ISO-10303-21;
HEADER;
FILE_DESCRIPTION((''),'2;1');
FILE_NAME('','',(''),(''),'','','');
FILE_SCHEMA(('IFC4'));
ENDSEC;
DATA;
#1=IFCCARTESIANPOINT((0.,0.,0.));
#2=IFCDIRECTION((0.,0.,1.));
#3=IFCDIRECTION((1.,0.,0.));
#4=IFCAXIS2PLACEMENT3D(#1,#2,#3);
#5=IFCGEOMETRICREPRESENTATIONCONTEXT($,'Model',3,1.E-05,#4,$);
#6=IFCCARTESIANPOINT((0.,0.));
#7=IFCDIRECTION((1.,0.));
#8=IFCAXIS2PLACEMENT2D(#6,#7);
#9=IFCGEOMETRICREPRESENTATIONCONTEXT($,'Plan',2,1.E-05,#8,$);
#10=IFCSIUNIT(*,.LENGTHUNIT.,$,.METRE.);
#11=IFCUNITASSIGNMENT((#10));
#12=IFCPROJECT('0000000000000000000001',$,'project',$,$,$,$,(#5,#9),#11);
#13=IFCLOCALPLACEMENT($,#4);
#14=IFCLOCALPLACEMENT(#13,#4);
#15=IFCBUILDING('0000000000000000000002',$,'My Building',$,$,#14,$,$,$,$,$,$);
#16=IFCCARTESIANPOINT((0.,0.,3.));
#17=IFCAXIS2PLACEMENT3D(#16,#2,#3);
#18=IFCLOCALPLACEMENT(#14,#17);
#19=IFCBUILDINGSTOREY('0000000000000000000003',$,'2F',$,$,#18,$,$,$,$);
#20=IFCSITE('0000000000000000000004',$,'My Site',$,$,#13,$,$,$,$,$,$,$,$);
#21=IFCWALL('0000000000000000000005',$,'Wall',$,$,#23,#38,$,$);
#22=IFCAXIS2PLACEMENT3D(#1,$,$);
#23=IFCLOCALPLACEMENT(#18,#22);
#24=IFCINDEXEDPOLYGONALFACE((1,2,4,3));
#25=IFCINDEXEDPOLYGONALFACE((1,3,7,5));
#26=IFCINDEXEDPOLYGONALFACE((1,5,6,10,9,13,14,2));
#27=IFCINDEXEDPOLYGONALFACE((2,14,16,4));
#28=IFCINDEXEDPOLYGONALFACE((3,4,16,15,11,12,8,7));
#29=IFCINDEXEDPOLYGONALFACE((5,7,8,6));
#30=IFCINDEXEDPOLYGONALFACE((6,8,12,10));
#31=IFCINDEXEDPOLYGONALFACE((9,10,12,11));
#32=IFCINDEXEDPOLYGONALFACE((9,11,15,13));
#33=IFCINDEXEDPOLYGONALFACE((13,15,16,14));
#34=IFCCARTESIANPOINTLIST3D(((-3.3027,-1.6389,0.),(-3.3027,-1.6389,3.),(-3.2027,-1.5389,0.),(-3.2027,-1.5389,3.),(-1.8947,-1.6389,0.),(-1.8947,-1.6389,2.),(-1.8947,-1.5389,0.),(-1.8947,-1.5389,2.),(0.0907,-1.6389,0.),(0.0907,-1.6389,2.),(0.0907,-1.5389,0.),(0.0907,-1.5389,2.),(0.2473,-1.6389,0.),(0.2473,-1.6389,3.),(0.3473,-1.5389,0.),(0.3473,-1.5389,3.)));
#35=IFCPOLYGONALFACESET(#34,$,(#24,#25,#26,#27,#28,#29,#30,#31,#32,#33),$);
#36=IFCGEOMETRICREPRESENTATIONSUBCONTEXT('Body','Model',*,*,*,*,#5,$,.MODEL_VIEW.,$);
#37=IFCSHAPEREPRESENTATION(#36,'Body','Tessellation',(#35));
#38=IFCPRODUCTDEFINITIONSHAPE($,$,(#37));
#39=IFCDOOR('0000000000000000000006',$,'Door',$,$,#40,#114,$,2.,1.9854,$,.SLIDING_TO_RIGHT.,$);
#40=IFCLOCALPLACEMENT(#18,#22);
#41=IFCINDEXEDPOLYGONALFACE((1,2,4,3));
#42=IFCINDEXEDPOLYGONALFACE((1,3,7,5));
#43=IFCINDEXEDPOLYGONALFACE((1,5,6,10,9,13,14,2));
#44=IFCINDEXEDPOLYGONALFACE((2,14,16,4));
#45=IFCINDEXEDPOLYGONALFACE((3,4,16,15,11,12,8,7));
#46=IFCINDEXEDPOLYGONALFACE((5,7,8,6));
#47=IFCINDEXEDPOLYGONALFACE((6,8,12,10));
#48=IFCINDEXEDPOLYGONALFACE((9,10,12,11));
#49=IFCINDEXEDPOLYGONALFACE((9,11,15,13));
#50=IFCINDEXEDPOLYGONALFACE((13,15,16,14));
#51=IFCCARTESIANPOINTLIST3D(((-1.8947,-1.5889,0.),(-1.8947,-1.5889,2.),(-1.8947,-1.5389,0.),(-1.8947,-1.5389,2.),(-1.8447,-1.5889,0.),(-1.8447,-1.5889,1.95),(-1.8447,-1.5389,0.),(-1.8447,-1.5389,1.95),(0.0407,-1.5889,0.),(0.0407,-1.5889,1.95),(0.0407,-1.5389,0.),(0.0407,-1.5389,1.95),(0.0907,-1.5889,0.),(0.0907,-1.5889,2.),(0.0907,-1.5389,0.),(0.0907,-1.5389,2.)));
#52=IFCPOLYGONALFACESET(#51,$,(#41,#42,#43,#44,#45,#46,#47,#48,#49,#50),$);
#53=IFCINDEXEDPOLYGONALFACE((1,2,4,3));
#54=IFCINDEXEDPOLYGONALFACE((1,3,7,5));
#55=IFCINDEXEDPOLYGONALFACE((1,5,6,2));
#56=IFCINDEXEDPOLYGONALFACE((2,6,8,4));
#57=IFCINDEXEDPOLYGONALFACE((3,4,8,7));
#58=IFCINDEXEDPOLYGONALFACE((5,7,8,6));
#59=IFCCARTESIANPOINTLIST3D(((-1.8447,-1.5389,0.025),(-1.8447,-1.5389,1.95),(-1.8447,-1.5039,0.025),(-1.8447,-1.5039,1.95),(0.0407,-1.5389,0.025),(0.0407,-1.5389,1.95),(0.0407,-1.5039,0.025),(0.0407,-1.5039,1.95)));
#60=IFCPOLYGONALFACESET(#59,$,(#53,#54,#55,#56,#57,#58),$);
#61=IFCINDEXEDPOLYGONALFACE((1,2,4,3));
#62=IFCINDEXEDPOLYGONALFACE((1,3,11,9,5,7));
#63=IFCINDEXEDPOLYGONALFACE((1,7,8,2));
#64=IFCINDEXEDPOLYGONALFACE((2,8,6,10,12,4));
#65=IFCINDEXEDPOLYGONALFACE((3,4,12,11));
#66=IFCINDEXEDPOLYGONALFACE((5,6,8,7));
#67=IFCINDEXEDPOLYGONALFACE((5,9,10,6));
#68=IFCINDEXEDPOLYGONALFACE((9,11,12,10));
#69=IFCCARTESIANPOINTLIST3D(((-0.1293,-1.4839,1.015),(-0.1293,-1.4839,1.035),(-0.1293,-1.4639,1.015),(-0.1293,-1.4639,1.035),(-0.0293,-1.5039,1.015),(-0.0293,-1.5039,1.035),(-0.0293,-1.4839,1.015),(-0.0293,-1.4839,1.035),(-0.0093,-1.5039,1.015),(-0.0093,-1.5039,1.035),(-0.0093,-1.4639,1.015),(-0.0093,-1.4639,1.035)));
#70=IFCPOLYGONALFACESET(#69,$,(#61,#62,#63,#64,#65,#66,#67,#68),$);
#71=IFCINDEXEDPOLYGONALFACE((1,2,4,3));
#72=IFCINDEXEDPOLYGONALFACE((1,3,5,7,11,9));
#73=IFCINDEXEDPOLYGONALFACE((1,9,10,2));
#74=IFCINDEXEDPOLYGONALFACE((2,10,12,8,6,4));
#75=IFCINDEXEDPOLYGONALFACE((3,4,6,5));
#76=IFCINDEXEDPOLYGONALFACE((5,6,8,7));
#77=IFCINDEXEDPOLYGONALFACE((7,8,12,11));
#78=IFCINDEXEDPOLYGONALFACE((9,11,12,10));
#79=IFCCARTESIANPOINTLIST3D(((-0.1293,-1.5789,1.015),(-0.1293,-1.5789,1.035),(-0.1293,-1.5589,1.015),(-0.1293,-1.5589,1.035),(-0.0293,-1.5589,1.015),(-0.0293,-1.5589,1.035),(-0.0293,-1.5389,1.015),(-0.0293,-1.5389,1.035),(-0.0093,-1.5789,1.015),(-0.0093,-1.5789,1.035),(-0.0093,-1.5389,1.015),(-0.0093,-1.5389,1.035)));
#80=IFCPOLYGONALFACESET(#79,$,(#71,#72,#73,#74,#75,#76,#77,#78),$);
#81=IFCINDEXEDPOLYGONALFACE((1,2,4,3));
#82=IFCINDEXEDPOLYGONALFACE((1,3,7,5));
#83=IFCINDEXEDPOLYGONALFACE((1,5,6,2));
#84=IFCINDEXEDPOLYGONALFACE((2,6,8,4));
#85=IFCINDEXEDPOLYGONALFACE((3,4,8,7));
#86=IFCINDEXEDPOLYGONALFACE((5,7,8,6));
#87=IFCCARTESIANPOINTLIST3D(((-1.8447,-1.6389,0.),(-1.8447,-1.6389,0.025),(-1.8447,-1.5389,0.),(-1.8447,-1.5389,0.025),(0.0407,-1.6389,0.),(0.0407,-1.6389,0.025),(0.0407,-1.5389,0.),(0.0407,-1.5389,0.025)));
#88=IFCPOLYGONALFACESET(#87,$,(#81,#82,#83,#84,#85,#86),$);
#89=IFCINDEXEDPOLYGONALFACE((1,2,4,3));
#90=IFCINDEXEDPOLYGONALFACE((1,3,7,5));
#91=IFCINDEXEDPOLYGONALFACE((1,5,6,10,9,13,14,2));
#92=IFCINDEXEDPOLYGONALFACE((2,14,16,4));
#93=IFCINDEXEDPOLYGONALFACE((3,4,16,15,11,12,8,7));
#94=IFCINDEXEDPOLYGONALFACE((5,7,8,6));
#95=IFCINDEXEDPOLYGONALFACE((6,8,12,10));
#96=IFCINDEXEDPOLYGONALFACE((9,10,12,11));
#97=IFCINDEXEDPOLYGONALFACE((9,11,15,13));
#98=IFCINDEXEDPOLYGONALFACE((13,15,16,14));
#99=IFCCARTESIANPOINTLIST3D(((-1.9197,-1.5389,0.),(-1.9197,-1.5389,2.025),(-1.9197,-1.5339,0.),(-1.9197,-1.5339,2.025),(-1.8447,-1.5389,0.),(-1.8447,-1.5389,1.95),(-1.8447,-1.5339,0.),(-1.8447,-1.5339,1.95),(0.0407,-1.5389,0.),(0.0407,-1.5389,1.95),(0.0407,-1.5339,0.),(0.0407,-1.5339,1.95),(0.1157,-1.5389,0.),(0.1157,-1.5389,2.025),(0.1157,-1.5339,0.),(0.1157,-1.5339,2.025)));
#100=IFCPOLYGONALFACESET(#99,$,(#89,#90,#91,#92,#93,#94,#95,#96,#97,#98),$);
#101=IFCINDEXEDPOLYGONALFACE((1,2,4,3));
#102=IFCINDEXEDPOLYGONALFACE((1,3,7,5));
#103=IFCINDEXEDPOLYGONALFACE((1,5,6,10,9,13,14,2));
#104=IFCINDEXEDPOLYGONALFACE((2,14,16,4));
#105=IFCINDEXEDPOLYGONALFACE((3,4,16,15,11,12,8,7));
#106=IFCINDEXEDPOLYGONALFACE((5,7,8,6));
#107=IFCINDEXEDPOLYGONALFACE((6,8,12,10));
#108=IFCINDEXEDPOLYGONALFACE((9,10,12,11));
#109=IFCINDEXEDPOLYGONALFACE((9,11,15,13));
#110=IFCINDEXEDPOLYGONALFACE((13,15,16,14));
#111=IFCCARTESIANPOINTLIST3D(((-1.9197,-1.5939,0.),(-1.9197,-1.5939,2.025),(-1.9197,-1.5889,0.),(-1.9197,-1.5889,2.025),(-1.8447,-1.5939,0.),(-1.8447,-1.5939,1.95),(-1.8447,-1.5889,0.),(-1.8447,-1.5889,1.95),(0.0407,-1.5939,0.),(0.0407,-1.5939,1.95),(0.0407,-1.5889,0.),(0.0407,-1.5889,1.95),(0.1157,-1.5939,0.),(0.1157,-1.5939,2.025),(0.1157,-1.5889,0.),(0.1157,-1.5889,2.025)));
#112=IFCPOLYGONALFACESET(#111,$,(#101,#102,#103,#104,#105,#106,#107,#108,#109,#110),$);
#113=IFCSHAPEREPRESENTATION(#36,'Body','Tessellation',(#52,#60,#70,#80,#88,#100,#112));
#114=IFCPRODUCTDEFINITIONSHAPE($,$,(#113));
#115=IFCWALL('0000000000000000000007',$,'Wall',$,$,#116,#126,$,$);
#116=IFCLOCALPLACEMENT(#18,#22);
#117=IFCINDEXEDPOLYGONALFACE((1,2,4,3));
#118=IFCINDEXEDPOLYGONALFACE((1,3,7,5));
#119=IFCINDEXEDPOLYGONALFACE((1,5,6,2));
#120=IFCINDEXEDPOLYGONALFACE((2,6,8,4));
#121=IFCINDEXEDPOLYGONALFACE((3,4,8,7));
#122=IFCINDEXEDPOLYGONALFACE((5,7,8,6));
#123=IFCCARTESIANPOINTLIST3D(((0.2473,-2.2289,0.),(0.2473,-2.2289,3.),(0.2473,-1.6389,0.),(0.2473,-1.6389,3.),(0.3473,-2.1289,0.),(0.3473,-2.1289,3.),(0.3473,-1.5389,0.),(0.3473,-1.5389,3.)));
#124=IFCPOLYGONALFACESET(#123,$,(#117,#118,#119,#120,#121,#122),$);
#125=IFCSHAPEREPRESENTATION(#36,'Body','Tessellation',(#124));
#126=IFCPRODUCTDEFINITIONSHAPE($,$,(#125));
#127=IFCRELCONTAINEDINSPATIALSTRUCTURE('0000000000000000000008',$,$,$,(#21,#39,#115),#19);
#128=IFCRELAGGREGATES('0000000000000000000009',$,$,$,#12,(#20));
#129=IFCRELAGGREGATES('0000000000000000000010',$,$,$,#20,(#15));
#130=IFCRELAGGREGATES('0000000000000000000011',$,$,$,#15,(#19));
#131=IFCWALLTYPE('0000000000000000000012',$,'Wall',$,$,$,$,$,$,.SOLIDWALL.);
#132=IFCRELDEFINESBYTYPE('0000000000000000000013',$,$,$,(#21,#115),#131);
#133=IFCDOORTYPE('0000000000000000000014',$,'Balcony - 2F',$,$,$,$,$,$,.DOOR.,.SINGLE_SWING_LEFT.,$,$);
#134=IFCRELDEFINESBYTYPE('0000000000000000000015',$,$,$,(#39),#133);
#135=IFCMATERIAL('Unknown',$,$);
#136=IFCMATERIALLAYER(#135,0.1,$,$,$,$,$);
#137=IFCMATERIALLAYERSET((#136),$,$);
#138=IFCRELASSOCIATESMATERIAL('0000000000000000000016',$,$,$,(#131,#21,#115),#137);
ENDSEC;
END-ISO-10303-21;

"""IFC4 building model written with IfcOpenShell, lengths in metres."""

from ifc_helpers import new_model, entity, si_unit, frame, origin_with_axes, origin_2d_with_axis, place, context, subcontext, project, spatial, line, indexed_curve, outline, extrude, shape, source, transform, mapped, material, layer, layer_set, layer_usage, type_object, type_shapes, element, fill, save


model = new_model("IFC4")

# Units and contexts
model_context = context("Model", 3, precision=1e-05, world=origin_with_axes())
plan_context = context("Plan", 2, precision=1e-05, world=origin_2d_with_axis())
body_context_1 = subcontext(model_context, "Body", "Model", "MODEL_VIEW")
body_context_2 = subcontext(plan_context, "Body", "Plan", "PLAN_VIEW")
ifc_project = project(units=[si_unit("LENGTHUNIT", "METRE")], contexts=[model_context, plan_context])

# Site, building, storey
site_placement = place(None, origin_with_axes())
site = spatial("IfcSite", under=ifc_project, at=site_placement, Name="My Site")
building_placement = place(site_placement, origin_with_axes())
building = spatial("IfcBuilding", under=site, at=building_placement, Name="My Building")
storey_placement = place(building_placement, frame((0.0, 0.0, 3.0), z_axis=(0.0, 0.0, 1.0), x_axis=(1.0, 0.0, 0.0)))
storey = spatial("IfcBuildingStorey", under=building, at=storey_placement, Name="2F")

# Shared definitions
ifc_material = material(Name="Unknown")
ifc_layer = layer(ifc_material, 0.1)
ifc_layer_set = layer_set([ifc_layer])
wall_type = type_object("IfcWallType", Name="Wall", PredefinedType="SOLIDWALL", material=ifc_layer_set)

# Wall, opening, door
ifc_layer_usage_1 = layer_usage(ifc_layer_set, "AXIS2", "POSITIVE", 0.0)
wall_1_placement = place(storey_placement, frame((-3.3027, -1.6389, 0.0), z_axis=(0.0, 0.0, 1.0), x_axis=(1.0, 0.0, 0.0)))
wall_1 = element("IfcWall", 1, at=wall_1_placement, inside=storey, type_object=wall_type, material=ifc_layer_usage_1, Name="Wall", context=body_context_1, shape_type="SweptSolid", body=[
    extrude(outline(indexed_curve([(0.0, 0.0), (0.1, 0.1), (3.65, 0.1), (3.55, 0.0)], segments=[line(1, 2, 3, 4, 1)])), origin_with_axes(), (0.0, 0.0, 1.0), 3.0),
])
shared_shape_1 = source(origin_with_axes(), body_context_1, "Body", "SweptSolid", [
    extrude(outline(indexed_curve([(0.0, 0.0), (1.9854, 0.0), (1.9854, 2.0), (0.0, 2.0)], segments=[line(1, 2, 3, 4, 1)])), frame((0.0, -0.6, 0.0), z_axis=(0.0, -1.0, 0.0), x_axis=(1.0, 0.0, 0.0)), (0.0, 0.0, -1.0), 1.2),
])
opening_1_placement = place(wall_1_placement, frame((3.3934, 0.1, 0.0), z_axis=(0.0, 0.0, 1.0), x_axis=(-1.0, 0.0, 0.0)))
opening_1 = element("IfcOpeningElement", 2, at=opening_1_placement, cuts=wall_1, PredefinedType="OPENING", context=body_context_1, shape_type="MappedRepresentation", body=[
    mapped(shared_shape_1, transform((0.0, 0.0, 0.0), x_axis=(1.0, 0.0, 0.0), y_axis=(0.0, 1.0, 0.0), z_axis=(0.0, 0.0, 1.0), scale=1.0)),
])
door_type_1 = type_object("IfcDoorType", Name="Balcony - 2F", OperationType="SINGLE_SWING_LEFT", PredefinedType="DOOR")
shared_shape_2 = source(origin_with_axes(), body_context_1, "Body", "SweptSolid", [
    extrude(outline(indexed_curve([(0.0, 0.0), (0.0, 2.0), (1.9854, 2.0), (1.9854, 0.0), (1.9354, 0.0), (1.9354, 1.95), (0.05, 1.95), (0.05, 0.0)], segments=[line(1, 2, 3, 4, 5, 6, 7, 8, 1)])), frame((0.0, 0.0, 0.0), z_axis=(0.0, -1.0, 0.0), x_axis=(1.0, 0.0, 0.0)), (0.0, 0.0, -1.0), 0.05),
    extrude(outline(indexed_curve([(0.0, 0.0), (1.8854, 0.0), (1.8854, 0.035), (0.0, 0.035)], segments=[line(1, 2, 3, 4, 1)])), frame((0.05, -0.035, 0.025), z_axis=(0.0, 0.0, 1.0), x_axis=(1.0, 0.0, 0.0)), (0.0, 0.0, 1.0), 1.925),
    extrude(outline(indexed_curve([(0.0, 0.0), (0.0, -0.04), (0.12, -0.04), (0.12, -0.02), (0.02, -0.02), (0.02, 0.0)], segments=[line(1, 2, 3, 4, 5, 6, 1)])), frame((0.1, -0.035, 1.015), z_axis=(0.0, 0.0, 1.0), x_axis=(1.0, 0.0, 0.0)), (0.0, 0.0, 1.0), 0.02),
    extrude(outline(indexed_curve([(0.0, 0.0), (0.0, 0.04), (0.12, 0.04), (0.12, 0.02), (0.02, 0.02), (0.02, 0.0)], segments=[line(1, 2, 3, 4, 5, 6, 1)])), frame((0.1, 0.0, 1.015), z_axis=(0.0, 0.0, 1.0), x_axis=(1.0, 0.0, 0.0)), (0.0, 0.0, 1.0), 0.02),
    extrude(outline(indexed_curve([(0.0, 0.0), (1.8854, 0.0), (1.8854, 0.1), (0.0, 0.1)], segments=[line(1, 2, 3, 4, 1)])), frame((0.05, 0.0, 0.0), z_axis=(0.0, 0.0, 1.0), x_axis=(1.0, 0.0, 0.0)), (0.0, 0.0, 1.0), 0.025),
    extrude(outline(indexed_curve([(0.0, 0.0), (0.0, 2.025), (2.0354, 2.025), (2.0354, 0.0), (1.9604, 0.0), (1.9604, 1.95), (0.075, 1.95), (0.075, 0.0)], segments=[line(1, 2, 3, 4, 5, 6, 7, 8, 1)])), frame((-0.025, -0.005, 0.0), z_axis=(0.0, -1.0, 0.0), x_axis=(1.0, 0.0, 0.0)), (0.0, 0.0, -1.0), 0.005),
    extrude(outline(indexed_curve([(0.0, 0.0), (0.0, 2.025), (2.0354, 2.025), (2.0354, 0.0), (1.9604, 0.0), (1.9604, 1.95), (0.075, 1.95), (0.075, 0.0)], segments=[line(1, 2, 3, 4, 5, 6, 7, 8, 1)])), frame((-0.025, 0.05, 0.0), z_axis=(0.0, -1.0, 0.0), x_axis=(1.0, 0.0, 0.0)), (0.0, 0.0, -1.0), 0.005),
])
shared_shape_3 = source(origin_with_axes(), body_context_2, "Body", "Curve2D", [
    entity("IfcIndexedPolyCurve", entity("IfcCartesianPointList2D", [[0.0, 0.0], [0.05, 0.0], [0.05, 0.05], [0.0, 0.05]]), [entity("IfcLineIndex", [1, 2, 3, 4, 1])]),
    entity("IfcIndexedPolyCurve", entity("IfcCartesianPointList2D", [[1.9854, 0.0], [1.9354, 0.0], [1.9354, 0.05], [1.9854, 0.05]]), [entity("IfcLineIndex", [1, 2, 3, 4, 1])]),
    entity("IfcIndexedPolyCurve", entity("IfcCartesianPointList2D", [[2.8782, -0.035], [0.9927, -0.035], [0.9927, 0.0], [2.8782, 0.0]]), [entity("IfcLineIndex", [1, 2, 3, 4, 1])]),
])
type_shapes(door_type_1, [shared_shape_2, shared_shape_3])
door_1_placement = place(opening_1_placement, frame((0.0, 0.0, 0.0), z_axis=(0.0, 0.0, 1.0), x_axis=(1.0, 0.0, 0.0)))
door_1 = element("IfcDoor", 3, at=door_1_placement, inside=storey, type_object=door_type_1, Name="Door", OperationType="SLIDING_TO_RIGHT", OverallHeight=2.0, OverallWidth=1.9854, shapes=[
    shape(body_context_1, "Body", "MappedRepresentation", [mapped(shared_shape_2, transform((0.0, 0.0, 0.0), x_axis=(1.0, 0.0, 0.0), y_axis=(0.0, 1.0, 0.0), z_axis=(0.0, 0.0, 1.0), scale=1.0))]),
    shape(body_context_2, "Body", "MappedRepresentation", [mapped(shared_shape_3, transform((0.0, 0.0, 0.0), x_axis=(1.0, 0.0, 0.0), y_axis=(0.0, 1.0, 0.0), z_axis=(0.0, 0.0, 1.0), scale=1.0))]),
])
fill(opening_1, door_1)

# Wall
ifc_layer_usage_2 = layer_usage(ifc_layer_set, "AXIS2", "POSITIVE", 0.0)
wall_2_placement = place(storey_placement, frame((0.2473, -1.6389, 0.0), z_axis=(0.0, 0.0, 1.0), x_axis=(0.0, -1.0, 0.0)))
element("IfcWall", 4, at=wall_2_placement, inside=storey, type_object=wall_type, material=ifc_layer_usage_2, Name="Wall", context=body_context_1, shape_type="SweptSolid", body=[
    extrude(outline(indexed_curve([(0.0, 0.0), (-0.1, 0.1), (0.49, 0.1), (0.59, 0.0)], segments=[line(1, 2, 3, 4, 1)])), origin_with_axes(), (0.0, 0.0, 1.0), 3.0),
])

save(model, "model.ifc")
